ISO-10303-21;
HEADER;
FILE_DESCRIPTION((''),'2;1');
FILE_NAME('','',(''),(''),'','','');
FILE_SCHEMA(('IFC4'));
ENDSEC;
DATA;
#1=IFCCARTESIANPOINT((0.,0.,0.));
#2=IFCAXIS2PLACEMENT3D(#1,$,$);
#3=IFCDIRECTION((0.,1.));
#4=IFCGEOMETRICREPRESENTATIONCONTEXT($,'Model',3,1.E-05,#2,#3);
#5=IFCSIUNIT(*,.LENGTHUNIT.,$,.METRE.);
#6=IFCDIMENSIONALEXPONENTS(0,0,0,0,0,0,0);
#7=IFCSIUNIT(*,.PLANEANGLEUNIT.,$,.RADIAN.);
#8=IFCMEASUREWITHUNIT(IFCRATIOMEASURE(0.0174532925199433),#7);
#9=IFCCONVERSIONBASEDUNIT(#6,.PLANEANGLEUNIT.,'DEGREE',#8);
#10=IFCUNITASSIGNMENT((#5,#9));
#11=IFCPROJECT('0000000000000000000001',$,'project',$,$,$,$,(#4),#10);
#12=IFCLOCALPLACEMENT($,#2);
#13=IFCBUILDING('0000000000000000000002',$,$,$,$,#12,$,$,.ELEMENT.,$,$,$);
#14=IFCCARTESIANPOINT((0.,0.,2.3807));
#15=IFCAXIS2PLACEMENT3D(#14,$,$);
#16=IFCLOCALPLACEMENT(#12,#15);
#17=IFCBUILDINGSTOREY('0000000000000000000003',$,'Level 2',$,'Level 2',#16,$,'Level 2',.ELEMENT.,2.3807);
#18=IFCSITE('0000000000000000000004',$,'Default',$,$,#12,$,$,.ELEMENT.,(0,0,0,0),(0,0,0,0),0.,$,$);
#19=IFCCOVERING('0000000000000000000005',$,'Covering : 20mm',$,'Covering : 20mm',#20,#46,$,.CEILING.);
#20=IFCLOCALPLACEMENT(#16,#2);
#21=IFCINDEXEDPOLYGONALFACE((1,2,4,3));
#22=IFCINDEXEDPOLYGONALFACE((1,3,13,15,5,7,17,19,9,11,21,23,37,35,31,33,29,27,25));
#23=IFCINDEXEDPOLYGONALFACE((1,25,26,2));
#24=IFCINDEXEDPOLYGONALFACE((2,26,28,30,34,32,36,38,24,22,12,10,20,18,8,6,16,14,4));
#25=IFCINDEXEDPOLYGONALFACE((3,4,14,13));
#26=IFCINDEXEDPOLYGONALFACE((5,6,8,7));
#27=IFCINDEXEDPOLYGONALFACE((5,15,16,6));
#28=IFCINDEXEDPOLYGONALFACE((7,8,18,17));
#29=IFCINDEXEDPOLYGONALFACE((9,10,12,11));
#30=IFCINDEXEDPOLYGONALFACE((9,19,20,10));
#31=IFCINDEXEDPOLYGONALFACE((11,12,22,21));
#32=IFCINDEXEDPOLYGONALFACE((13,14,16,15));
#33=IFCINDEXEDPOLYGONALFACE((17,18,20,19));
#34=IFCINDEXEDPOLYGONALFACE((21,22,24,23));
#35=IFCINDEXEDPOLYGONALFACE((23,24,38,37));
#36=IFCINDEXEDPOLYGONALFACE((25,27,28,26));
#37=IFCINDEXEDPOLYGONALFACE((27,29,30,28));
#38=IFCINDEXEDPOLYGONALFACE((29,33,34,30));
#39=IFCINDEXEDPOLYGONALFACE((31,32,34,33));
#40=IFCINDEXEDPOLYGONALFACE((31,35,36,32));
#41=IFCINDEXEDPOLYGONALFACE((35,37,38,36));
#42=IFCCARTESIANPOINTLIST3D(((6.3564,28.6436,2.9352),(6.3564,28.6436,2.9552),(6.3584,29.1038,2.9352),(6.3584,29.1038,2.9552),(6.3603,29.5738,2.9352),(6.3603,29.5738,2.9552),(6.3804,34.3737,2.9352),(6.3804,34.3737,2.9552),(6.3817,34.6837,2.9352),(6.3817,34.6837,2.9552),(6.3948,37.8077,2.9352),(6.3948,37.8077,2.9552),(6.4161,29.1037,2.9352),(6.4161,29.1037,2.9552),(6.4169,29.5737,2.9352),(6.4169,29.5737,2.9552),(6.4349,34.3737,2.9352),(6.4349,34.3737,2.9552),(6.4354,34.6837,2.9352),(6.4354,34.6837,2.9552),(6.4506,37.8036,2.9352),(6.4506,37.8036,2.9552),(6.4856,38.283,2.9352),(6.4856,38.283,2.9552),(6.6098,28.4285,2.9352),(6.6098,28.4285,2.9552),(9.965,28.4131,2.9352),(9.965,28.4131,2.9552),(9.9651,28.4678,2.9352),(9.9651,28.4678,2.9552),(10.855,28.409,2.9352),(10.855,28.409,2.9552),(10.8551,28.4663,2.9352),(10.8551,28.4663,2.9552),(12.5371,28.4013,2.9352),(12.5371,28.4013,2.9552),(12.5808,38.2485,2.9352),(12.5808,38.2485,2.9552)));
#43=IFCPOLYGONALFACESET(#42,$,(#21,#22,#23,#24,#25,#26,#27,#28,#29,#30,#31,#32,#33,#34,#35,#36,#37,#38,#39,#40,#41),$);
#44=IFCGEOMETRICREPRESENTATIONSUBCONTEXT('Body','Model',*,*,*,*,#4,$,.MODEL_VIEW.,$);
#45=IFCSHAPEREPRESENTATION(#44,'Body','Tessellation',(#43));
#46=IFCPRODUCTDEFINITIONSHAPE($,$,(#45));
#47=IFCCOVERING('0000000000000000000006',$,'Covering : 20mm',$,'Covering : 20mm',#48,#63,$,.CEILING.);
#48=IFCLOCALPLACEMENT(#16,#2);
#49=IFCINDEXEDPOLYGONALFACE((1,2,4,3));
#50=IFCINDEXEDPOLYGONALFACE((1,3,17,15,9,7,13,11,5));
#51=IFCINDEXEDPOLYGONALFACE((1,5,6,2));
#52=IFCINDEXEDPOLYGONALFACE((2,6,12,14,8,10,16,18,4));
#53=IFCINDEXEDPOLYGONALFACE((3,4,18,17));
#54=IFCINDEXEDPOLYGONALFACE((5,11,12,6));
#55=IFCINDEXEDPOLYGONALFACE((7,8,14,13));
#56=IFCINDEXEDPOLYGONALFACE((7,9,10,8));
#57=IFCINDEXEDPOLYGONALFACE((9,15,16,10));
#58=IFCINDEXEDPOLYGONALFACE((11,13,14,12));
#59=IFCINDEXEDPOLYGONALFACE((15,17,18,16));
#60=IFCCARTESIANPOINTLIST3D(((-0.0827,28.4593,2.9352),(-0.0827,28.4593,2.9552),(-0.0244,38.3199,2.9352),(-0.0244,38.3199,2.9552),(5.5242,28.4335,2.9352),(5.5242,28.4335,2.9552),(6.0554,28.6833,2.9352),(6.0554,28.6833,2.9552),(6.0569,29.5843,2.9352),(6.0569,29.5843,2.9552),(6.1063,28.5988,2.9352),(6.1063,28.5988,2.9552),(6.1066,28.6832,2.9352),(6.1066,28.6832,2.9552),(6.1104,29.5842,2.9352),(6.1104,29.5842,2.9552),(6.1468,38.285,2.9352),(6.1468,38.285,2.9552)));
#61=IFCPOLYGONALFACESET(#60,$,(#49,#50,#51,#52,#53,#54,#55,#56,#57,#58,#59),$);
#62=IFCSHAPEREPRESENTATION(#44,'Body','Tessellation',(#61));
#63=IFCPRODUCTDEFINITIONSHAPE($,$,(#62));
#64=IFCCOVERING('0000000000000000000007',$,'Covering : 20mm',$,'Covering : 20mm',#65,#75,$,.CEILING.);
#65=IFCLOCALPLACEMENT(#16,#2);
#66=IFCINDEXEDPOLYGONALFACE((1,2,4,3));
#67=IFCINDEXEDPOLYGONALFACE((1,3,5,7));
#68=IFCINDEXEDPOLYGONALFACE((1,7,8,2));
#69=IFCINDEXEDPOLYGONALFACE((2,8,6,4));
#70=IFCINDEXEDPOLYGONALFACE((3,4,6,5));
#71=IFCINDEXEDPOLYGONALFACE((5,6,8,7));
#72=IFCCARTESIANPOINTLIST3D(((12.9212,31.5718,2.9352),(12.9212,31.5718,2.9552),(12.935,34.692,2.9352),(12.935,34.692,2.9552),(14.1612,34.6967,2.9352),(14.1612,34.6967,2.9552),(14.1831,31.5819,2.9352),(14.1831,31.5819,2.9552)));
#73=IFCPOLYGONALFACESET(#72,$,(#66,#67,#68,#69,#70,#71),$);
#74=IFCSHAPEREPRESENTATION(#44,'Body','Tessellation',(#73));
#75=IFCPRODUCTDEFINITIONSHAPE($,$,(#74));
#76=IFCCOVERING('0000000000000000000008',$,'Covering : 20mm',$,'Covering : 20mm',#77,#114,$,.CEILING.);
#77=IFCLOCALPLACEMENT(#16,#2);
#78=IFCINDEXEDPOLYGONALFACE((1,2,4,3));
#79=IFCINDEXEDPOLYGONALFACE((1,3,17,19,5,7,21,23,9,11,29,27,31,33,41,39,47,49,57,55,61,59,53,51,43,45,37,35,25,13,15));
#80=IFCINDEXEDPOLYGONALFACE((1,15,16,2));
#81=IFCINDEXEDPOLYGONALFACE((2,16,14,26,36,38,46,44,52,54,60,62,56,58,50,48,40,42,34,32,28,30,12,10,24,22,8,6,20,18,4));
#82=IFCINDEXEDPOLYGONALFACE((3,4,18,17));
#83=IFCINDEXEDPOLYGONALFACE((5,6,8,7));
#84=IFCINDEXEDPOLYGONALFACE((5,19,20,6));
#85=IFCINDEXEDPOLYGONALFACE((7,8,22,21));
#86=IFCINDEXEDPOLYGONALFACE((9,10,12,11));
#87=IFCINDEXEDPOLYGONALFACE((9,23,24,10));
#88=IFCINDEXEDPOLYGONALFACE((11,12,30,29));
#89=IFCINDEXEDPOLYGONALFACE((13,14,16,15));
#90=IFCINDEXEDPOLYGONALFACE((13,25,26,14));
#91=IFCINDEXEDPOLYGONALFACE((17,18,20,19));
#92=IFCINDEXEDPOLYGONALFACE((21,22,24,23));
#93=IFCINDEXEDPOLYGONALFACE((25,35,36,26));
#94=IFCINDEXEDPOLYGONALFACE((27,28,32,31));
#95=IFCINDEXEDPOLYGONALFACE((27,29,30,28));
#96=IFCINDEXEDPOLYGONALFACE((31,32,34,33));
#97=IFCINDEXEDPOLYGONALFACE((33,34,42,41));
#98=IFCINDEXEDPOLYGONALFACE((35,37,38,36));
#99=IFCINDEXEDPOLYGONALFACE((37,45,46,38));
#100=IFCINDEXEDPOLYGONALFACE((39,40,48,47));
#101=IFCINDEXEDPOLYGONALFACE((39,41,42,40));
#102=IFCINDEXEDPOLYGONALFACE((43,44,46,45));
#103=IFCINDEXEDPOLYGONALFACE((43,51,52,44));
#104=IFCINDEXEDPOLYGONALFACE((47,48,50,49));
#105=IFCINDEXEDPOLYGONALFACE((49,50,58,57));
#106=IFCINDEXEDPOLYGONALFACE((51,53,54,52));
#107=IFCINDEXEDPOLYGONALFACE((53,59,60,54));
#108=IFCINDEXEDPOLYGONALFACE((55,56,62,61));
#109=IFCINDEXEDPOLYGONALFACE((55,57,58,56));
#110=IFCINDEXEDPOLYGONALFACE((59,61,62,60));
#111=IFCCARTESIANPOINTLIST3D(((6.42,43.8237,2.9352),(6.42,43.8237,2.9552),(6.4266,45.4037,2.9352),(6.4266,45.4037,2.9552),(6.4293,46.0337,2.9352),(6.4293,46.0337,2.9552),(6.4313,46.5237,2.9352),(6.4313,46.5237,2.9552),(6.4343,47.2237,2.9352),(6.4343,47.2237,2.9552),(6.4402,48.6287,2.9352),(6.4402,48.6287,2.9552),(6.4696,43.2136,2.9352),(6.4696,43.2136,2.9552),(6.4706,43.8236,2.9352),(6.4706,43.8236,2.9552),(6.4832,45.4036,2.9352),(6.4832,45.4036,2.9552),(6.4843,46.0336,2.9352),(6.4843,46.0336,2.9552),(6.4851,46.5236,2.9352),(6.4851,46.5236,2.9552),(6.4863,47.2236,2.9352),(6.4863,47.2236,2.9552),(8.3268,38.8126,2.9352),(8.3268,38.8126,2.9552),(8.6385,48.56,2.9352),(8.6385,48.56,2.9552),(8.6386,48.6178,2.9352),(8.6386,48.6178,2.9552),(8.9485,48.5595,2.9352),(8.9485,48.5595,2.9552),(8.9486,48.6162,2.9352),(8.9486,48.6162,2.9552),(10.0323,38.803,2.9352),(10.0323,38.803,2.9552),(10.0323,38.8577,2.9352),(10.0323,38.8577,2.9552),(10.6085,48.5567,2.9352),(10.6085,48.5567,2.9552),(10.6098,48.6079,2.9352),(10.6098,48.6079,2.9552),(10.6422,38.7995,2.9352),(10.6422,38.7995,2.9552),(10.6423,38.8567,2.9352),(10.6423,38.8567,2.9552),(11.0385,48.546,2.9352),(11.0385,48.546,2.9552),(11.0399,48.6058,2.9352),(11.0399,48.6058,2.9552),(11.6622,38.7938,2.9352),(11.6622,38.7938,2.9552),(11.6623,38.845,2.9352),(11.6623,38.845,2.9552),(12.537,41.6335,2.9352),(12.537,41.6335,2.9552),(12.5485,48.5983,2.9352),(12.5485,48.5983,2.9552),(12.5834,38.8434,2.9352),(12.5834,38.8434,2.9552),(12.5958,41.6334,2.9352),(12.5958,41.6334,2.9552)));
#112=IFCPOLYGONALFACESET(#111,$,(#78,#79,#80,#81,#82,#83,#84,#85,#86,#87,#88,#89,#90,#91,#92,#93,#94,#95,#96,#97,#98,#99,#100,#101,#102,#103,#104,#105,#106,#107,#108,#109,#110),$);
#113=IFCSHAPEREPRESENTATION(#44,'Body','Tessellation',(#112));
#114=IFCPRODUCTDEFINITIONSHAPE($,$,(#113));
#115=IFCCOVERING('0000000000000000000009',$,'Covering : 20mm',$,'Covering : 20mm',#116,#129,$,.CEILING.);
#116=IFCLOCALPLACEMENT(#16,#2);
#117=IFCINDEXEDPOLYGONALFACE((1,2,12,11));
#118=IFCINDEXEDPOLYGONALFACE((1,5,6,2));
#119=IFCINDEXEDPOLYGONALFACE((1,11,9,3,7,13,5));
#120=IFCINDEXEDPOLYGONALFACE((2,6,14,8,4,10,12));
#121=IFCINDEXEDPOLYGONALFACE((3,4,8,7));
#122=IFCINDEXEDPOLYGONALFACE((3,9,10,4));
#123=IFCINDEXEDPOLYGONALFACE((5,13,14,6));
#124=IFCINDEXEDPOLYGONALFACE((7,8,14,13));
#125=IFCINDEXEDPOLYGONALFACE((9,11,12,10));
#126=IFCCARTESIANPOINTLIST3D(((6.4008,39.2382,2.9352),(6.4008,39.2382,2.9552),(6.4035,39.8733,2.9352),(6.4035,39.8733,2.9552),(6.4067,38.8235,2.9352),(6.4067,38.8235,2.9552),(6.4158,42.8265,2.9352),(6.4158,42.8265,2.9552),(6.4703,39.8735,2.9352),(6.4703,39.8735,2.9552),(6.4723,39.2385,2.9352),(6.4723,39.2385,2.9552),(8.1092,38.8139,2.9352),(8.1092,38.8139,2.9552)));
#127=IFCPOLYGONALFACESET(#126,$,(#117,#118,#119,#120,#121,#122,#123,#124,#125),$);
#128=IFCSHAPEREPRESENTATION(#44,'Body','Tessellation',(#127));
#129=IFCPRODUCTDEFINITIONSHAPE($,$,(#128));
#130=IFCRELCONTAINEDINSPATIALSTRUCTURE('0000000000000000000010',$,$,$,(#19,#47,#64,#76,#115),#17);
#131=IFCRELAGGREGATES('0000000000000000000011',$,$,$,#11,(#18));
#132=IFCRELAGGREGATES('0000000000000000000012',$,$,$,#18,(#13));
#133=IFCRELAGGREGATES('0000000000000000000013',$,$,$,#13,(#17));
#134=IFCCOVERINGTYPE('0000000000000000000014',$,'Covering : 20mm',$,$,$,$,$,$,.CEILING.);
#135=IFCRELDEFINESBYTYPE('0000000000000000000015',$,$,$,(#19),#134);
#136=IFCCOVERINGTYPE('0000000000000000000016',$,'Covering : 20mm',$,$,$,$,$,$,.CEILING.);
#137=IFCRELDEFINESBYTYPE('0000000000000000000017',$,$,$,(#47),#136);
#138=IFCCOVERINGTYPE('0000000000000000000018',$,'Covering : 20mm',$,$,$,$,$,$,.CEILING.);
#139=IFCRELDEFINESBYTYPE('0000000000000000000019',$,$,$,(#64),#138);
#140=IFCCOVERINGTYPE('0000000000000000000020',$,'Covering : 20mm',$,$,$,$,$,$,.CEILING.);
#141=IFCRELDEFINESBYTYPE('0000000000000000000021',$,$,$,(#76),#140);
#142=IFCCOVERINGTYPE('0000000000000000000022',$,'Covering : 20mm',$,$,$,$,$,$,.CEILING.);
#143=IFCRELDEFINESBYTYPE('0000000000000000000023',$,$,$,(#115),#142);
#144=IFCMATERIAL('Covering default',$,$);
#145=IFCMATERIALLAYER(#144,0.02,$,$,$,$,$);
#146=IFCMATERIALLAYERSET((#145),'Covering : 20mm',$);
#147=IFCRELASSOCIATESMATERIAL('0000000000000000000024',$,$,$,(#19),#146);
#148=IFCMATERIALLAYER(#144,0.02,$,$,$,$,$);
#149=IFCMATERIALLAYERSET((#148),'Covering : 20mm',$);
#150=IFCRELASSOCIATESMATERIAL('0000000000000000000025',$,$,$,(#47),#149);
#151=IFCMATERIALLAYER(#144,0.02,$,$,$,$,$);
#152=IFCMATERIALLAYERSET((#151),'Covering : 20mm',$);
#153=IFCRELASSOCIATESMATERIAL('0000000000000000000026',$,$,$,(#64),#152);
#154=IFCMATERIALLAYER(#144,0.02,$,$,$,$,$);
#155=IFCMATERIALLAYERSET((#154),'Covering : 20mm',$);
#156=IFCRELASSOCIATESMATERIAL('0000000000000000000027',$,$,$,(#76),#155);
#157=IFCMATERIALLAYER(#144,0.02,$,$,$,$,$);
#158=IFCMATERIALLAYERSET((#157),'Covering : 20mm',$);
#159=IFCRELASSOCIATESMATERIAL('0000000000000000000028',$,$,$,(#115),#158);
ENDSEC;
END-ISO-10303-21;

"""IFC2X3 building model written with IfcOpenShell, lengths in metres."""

from ifc_helpers import new_model, entity, si_unit, converted_unit, direction, frame, origin, origin_with_axes, place, context, subcontext, project, spatial, polyline, outline, extrude, material, layer, layer_set, layer_usage, type_object, element, save


model = new_model("IFC2X3")

# Units and contexts
model_context = context("Model", 3, precision=1e-05, world=origin(), true_north=direction((0.0, 1.0)))
body_context = subcontext(model_context, "Body", "Model", "MODEL_VIEW")
ifc_project = project(units=[si_unit("LENGTHUNIT", "METRE"), converted_unit("PLANEANGLEUNIT", "DEGREE", entity("IfcRatioMeasure", 0.0174532925199433), si_unit("PLANEANGLEUNIT", "RADIAN"), dimensions=[0, 0, 0, 0, 0, 0, 0])], contexts=[model_context])

# Site, building, storey
placement = place(None, origin())
site = spatial("IfcSite", under=ifc_project, at=placement, Name="Default", CompositionType="ELEMENT", RefLatitude=(0, 0, 0, 0), RefLongitude=(0, 0, 0, 0), RefElevation=0.0)
building = spatial("IfcBuilding", under=site, at=placement, CompositionType="ELEMENT")
storey_placement = place(placement, frame((0.0, 0.0, 2.3807)))
storey = spatial("IfcBuildingStorey", under=building, at=storey_placement, Name="Level 2", ObjectType="Level 2", LongName="Level 2", CompositionType="ELEMENT", Elevation=2.3807)

# Coverings
ifc_material_1 = material(Name="Covering default")
ifc_layer_1 = layer(ifc_material_1, 0.02)
ifc_layer_set_1 = layer_set([ifc_layer_1], Name="Covering : 20mm")
ifc_layer_usage_1 = layer_usage(ifc_layer_set_1, "AXIS3", "POSITIVE", 0.0)
covering_type_1 = type_object("IfcCoveringType", Name="Covering : 20mm", PredefinedType="CEILING")
covering_1_placement = place(placement, frame((0.0, 0.0, 5.3159)))
element("IfcCovering", 1, at=covering_1_placement, inside=storey, type_object=covering_type_1, material=ifc_layer_usage_1, Name="Covering : 20mm", ObjectType="Covering : 20mm", PredefinedType="CEILING", context=body_context, shape_type="SweptSolid", body=[
    extrude(outline(polyline([(6.3584, 29.1038), (6.4161, 29.1037), (6.4169, 29.5737), (6.3603, 29.5738), (6.3804, 34.3737), (6.4349, 34.3737), (6.4354, 34.6837), (6.3817, 34.6837), (6.3948, 37.8077), (6.4506, 37.8036), (6.4856, 38.283), (12.5808, 38.2485), (12.5371, 28.4013), (10.855, 28.409), (10.8551, 28.4663), (9.9651, 28.4678), (9.965, 28.4131), (6.6098, 28.4285), (6.3564, 28.6436), (6.3584, 29.1038)])), origin_with_axes(), (0.0, 0.0, 1.0), 0.02),
])
ifc_layer_2 = layer(ifc_material_1, 0.02)
ifc_layer_set_2 = layer_set([ifc_layer_2], Name="Covering : 20mm")
ifc_layer_usage_2 = layer_usage(ifc_layer_set_2, "AXIS3", "POSITIVE", 0.0)
covering_type_2 = type_object("IfcCoveringType", Name="Covering : 20mm", PredefinedType="CEILING")
covering_2_placement = place(placement, frame((0.0, 0.0, 5.3159)))
element("IfcCovering", 2, at=covering_2_placement, inside=storey, type_object=covering_type_2, material=ifc_layer_usage_2, Name="Covering : 20mm", ObjectType="Covering : 20mm", PredefinedType="CEILING", context=body_context, shape_type="SweptSolid", body=[
    extrude(outline(polyline([(-0.0244, 38.3199), (6.1468, 38.285), (6.1104, 29.5842), (6.0569, 29.5843), (6.0554, 28.6833), (6.1066, 28.6832), (6.1063, 28.5988), (5.5242, 28.4335), (-0.0827, 28.4593), (-0.0244, 38.3199)])), origin_with_axes(), (0.0, 0.0, 1.0), 0.02),
])
ifc_layer_3 = layer(ifc_material_1, 0.02)
ifc_layer_set_3 = layer_set([ifc_layer_3], Name="Covering : 20mm")
ifc_layer_usage_3 = layer_usage(ifc_layer_set_3, "AXIS3", "POSITIVE", 0.0)
covering_type_3 = type_object("IfcCoveringType", Name="Covering : 20mm", PredefinedType="CEILING")
covering_3_placement = place(placement, frame((0.0, 0.0, 5.3159)))
element("IfcCovering", 3, at=covering_3_placement, inside=storey, type_object=covering_type_3, material=ifc_layer_usage_3, Name="Covering : 20mm", ObjectType="Covering : 20mm", PredefinedType="CEILING", context=body_context, shape_type="SweptSolid", body=[
    extrude(outline(polyline([(12.935, 34.692), (14.1612, 34.6967), (14.1831, 31.5819), (12.9212, 31.5718), (12.935, 34.692)])), origin_with_axes(), (0.0, 0.0, 1.0), 0.02),
])
ifc_layer_4 = layer(ifc_material_1, 0.02)
ifc_layer_set_4 = layer_set([ifc_layer_4], Name="Covering : 20mm")
ifc_layer_usage_4 = layer_usage(ifc_layer_set_4, "AXIS3", "POSITIVE", 0.0)
covering_type_4 = type_object("IfcCoveringType", Name="Covering : 20mm", PredefinedType="CEILING")
covering_4_placement = place(placement, frame((0.0, 0.0, 5.3159)))
element("IfcCovering", 4, at=covering_4_placement, inside=storey, type_object=covering_type_4, material=ifc_layer_usage_4, Name="Covering : 20mm", ObjectType="Covering : 20mm", PredefinedType="CEILING", context=body_context, shape_type="SweptSolid", body=[
    extrude(outline(polyline([(6.4266, 45.4037), (6.4832, 45.4036), (6.4843, 46.0336), (6.4293, 46.0337), (6.4313, 46.5237), (6.4851, 46.5236), (6.4863, 47.2236), (6.4343, 47.2237), (6.4402, 48.6287), (8.6386, 48.6178), (8.6385, 48.56), (8.9485, 48.5595), (8.9486, 48.6162), (10.6098, 48.6079), (10.6085, 48.5567), (11.0385, 48.546), (11.0399, 48.6058), (12.5485, 48.5983), (12.537, 41.6335), (12.5958, 41.6334), (12.5834, 38.8434), (11.6623, 38.845), (11.6622, 38.7938), (10.6422, 38.7995), (10.6423, 38.8567), (10.0323, 38.8577), (10.0323, 38.803), (8.3268, 38.8126), (6.4696, 43.2136), (6.4706, 43.8236), (6.42, 43.8237), (6.4266, 45.4037)])), origin_with_axes(), (0.0, 0.0, 1.0), 0.02),
])
ifc_layer_5 = layer(ifc_material_1, 0.02)
ifc_layer_set_5 = layer_set([ifc_layer_5], Name="Covering : 20mm")
ifc_layer_usage_5 = layer_usage(ifc_layer_set_5, "AXIS3", "POSITIVE", 0.0)
covering_type_5 = type_object("IfcCoveringType", Name="Covering : 20mm", PredefinedType="CEILING")
covering_5_placement = place(placement, frame((0.0, 0.0, 5.3159)))
element("IfcCovering", 5, at=covering_5_placement, inside=storey, type_object=covering_type_5, material=ifc_layer_usage_5, Name="Covering : 20mm", ObjectType="Covering : 20mm", PredefinedType="CEILING", context=body_context, shape_type="SweptSolid", body=[
    extrude(outline(polyline([(6.4067, 38.8235), (8.1092, 38.8139), (6.4158, 42.8265), (6.4035, 39.8733), (6.4703, 39.8735), (6.4723, 39.2385), (6.4008, 39.2382), (6.4067, 38.8235)])), origin_with_axes(), (0.0, 0.0, 1.0), 0.02),
])

save(model, "model.ifc")
